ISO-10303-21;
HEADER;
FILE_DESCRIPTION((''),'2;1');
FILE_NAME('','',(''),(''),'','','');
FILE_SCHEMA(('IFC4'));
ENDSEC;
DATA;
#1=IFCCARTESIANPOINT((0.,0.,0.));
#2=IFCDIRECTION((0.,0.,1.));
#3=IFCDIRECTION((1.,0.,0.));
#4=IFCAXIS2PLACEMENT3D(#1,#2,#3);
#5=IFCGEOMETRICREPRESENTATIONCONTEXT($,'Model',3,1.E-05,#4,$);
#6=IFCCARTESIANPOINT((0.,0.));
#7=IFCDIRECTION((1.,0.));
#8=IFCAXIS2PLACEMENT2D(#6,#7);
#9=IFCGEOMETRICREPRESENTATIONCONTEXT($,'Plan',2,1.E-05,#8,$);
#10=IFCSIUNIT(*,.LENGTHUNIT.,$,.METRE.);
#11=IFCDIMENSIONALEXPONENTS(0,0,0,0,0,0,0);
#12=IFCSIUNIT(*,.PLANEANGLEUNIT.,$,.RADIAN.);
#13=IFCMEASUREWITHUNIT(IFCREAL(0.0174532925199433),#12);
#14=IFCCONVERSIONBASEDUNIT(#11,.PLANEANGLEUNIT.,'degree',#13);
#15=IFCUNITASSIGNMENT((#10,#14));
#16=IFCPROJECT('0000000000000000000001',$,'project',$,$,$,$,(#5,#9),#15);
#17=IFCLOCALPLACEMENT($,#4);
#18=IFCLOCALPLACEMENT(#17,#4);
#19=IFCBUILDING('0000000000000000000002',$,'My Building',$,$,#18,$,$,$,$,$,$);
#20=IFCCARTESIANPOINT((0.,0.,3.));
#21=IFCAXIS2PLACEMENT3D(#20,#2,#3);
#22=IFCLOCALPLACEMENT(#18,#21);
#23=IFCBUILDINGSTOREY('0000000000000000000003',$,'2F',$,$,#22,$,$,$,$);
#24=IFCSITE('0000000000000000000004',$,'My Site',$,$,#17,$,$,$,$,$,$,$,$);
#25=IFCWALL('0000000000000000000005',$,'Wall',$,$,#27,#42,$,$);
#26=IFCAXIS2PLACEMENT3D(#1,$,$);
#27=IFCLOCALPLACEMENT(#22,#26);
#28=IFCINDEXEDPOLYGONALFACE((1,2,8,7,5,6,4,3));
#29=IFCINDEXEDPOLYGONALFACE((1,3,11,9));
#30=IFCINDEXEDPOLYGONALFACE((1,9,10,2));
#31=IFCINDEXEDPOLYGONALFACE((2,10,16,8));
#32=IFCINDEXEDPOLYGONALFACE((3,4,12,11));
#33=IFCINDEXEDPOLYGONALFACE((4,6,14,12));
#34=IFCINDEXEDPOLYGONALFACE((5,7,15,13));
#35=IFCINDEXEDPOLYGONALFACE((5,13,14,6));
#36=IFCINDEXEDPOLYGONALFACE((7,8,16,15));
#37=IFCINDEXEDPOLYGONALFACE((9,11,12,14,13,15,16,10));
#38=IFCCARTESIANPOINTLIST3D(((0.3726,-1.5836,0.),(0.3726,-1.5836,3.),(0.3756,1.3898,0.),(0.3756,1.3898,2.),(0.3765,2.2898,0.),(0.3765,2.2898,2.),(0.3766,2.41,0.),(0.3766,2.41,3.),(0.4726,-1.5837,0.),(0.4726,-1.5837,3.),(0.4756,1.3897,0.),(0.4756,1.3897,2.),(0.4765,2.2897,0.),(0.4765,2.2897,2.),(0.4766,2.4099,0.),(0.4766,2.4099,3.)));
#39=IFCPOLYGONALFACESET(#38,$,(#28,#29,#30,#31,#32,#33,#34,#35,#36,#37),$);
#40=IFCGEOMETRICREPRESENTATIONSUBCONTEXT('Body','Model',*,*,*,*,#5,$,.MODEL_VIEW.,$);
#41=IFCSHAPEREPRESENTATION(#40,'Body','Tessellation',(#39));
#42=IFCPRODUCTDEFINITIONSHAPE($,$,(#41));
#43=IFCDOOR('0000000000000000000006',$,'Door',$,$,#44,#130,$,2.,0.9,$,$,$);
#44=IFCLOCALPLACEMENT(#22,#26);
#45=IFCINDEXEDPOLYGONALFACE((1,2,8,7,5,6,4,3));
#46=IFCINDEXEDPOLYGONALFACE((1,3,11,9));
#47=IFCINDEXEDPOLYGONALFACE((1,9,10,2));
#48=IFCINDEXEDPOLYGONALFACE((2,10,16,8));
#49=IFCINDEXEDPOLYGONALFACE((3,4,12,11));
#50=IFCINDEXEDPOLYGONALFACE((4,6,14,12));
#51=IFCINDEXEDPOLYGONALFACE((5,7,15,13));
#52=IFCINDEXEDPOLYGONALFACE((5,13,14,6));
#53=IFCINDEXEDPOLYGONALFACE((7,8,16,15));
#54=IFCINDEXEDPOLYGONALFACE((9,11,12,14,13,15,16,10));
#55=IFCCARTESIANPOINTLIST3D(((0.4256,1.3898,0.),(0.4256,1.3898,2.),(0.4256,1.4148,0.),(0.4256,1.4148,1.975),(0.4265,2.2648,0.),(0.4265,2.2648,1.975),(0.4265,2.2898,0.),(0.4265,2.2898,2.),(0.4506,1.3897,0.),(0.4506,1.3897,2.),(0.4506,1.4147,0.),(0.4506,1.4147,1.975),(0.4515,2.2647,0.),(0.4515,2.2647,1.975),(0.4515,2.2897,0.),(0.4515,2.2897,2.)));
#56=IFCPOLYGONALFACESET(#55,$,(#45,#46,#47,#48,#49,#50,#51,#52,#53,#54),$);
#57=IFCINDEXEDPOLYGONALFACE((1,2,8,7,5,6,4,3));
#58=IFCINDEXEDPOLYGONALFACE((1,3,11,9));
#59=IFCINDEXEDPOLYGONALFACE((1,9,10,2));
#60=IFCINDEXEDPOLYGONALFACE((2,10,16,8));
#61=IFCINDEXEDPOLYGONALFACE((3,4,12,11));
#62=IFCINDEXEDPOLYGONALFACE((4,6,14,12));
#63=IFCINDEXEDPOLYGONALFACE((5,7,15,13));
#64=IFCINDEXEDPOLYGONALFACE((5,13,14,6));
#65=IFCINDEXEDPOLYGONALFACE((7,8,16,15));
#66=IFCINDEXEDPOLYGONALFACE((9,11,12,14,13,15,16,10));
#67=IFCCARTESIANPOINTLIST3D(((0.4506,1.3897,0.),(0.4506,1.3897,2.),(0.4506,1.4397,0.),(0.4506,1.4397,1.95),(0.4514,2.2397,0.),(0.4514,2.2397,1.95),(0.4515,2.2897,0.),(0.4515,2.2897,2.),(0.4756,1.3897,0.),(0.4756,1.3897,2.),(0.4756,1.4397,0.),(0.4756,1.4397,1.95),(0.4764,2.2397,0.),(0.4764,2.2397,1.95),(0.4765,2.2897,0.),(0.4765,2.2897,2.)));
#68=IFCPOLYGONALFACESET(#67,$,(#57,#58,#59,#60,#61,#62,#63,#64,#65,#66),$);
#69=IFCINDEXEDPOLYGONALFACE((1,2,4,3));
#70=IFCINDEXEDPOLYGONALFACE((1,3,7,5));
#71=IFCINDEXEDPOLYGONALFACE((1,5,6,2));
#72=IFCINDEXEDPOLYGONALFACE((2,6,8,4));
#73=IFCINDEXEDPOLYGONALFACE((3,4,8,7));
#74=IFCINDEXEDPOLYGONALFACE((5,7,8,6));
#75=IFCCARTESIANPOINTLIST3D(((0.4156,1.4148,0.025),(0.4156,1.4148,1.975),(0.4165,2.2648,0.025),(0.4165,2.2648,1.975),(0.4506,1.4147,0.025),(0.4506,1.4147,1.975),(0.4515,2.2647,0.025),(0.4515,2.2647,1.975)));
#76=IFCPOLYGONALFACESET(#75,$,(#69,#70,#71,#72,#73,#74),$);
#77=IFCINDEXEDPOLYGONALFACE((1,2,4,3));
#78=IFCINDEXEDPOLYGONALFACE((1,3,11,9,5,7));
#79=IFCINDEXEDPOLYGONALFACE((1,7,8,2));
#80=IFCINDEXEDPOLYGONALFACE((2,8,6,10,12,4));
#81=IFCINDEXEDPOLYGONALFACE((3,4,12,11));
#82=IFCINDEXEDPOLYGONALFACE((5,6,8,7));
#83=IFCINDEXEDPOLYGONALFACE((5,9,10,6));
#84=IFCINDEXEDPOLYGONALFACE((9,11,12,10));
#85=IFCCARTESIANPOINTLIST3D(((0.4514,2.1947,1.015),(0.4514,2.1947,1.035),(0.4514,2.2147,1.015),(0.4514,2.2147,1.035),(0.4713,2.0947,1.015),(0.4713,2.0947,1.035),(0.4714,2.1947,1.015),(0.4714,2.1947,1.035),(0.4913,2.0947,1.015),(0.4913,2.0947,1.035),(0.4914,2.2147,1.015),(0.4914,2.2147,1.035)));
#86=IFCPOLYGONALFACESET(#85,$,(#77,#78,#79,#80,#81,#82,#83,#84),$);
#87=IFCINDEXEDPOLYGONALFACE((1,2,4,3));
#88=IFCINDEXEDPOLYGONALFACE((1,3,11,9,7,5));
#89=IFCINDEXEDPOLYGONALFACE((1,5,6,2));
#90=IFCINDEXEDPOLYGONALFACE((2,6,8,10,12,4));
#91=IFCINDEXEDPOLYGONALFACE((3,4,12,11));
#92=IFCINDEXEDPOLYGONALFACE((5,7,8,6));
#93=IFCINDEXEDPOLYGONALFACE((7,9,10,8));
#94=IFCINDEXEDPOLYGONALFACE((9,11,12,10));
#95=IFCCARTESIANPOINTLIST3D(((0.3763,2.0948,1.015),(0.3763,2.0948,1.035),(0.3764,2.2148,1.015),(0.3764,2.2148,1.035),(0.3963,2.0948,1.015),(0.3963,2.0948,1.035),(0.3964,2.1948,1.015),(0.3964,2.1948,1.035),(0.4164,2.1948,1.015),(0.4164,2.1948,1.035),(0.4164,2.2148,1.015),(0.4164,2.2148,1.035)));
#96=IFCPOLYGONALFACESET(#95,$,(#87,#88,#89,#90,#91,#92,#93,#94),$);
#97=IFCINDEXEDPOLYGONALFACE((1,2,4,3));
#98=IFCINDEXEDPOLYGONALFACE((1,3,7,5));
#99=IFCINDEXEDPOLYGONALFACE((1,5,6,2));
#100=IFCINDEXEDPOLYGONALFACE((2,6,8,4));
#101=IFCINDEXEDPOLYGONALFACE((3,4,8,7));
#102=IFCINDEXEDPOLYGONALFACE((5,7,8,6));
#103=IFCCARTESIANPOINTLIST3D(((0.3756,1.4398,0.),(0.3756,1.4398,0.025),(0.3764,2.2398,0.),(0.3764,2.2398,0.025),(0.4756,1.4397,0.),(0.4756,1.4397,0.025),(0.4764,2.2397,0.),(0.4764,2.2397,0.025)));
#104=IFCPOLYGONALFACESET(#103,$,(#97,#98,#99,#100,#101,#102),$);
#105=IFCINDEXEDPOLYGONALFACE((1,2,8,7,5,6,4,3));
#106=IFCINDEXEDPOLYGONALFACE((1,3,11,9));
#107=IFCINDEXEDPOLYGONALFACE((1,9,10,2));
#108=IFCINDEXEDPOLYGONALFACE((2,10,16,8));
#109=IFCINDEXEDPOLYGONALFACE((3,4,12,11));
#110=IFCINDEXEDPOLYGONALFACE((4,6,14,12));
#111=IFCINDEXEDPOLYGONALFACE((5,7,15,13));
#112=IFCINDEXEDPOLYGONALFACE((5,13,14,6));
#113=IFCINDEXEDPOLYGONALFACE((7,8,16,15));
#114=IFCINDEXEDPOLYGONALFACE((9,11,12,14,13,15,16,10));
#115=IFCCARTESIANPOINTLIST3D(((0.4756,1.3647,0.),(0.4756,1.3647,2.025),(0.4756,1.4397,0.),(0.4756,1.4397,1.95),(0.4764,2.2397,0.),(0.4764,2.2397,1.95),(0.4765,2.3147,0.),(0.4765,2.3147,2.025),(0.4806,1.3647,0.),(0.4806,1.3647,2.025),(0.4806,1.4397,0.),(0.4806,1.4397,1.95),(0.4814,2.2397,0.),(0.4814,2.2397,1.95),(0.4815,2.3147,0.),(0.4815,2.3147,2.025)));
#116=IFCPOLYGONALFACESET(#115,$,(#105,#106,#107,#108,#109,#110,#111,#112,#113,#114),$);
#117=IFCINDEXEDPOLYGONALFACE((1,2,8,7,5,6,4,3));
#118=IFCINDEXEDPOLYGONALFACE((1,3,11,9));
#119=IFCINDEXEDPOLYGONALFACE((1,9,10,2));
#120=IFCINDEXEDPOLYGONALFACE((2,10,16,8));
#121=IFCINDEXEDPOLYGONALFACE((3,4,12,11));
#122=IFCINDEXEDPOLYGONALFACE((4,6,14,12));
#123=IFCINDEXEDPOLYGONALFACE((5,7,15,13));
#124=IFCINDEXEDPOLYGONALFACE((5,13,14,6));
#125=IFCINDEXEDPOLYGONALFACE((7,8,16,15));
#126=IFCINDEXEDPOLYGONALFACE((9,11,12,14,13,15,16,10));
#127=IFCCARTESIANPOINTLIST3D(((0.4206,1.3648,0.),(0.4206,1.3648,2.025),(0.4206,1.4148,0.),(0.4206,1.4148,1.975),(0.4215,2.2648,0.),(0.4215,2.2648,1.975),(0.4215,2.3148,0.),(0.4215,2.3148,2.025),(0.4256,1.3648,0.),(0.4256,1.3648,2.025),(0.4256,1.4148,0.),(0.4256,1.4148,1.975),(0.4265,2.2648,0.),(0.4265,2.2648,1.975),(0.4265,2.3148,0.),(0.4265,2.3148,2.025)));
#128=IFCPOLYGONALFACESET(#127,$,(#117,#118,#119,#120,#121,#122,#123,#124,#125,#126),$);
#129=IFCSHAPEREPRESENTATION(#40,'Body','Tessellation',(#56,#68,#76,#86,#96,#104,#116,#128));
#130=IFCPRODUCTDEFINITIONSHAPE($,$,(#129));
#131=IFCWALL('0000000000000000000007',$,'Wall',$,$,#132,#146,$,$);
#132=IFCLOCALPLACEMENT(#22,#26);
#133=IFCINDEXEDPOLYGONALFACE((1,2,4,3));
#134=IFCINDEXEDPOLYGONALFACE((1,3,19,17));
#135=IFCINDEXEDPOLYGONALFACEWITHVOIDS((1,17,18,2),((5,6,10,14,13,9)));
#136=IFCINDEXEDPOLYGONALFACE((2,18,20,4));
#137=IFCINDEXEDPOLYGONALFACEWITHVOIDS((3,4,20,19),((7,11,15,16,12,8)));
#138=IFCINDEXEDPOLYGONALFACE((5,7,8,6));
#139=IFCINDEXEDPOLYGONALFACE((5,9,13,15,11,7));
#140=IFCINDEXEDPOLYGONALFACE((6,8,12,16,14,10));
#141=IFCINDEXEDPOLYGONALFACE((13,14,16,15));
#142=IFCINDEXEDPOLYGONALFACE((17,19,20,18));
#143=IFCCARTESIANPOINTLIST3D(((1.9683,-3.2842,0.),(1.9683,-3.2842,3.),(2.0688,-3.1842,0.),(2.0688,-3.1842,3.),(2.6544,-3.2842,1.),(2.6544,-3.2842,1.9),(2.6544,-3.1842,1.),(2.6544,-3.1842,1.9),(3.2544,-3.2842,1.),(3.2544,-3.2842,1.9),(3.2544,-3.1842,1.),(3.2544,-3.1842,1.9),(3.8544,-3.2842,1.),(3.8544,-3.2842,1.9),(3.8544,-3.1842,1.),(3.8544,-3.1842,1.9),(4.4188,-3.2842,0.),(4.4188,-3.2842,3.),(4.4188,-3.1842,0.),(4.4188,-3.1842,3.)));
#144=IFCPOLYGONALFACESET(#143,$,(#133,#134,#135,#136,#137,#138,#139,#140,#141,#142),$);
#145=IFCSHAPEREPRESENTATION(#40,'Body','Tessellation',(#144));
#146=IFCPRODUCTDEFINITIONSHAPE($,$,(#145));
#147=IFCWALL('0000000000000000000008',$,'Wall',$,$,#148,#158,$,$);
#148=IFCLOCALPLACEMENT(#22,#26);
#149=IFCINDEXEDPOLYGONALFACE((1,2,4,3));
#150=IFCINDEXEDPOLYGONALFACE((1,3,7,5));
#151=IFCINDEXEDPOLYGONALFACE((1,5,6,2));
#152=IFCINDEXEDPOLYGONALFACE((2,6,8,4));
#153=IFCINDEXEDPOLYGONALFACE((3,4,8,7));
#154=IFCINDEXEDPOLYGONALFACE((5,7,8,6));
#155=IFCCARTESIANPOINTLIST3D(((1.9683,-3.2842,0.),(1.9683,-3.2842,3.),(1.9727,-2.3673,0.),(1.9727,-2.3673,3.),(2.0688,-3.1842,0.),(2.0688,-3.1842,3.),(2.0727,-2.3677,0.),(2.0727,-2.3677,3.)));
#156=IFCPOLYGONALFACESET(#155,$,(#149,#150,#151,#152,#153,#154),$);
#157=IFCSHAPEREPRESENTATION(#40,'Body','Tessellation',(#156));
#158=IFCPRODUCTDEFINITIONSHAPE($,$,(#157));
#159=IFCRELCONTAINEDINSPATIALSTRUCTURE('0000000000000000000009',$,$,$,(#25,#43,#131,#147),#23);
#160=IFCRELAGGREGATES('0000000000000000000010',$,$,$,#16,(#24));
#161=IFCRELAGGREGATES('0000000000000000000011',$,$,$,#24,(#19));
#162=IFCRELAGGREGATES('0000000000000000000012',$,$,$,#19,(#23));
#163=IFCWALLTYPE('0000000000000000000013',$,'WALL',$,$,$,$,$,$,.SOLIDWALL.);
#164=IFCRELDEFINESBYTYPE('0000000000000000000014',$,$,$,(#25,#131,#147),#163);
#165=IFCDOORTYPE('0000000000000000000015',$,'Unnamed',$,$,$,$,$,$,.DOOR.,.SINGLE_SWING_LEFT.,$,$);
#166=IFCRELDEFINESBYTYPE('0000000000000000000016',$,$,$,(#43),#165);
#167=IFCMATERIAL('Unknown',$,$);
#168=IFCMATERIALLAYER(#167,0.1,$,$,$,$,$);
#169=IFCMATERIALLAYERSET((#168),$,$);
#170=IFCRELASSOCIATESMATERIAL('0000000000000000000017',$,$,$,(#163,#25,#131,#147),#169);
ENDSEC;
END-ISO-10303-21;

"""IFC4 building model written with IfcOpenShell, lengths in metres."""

from ifc_helpers import new_model, entity, si_unit, converted_unit, frame, origin_with_axes, origin_2d_with_axis, place, context, subcontext, project, spatial, line, indexed_curve, outline, extrude, shape, source, transform, mapped, material, layer, layer_set, layer_usage, type_object, type_shapes, element, fill, save


model = new_model("IFC4")

# Units and contexts
model_context = context("Model", 3, precision=1e-05, world=origin_with_axes())
plan_context = context("Plan", 2, precision=1e-05, world=origin_2d_with_axis())
body_context_1 = subcontext(model_context, "Body", "Model", "MODEL_VIEW")
body_context_2 = subcontext(plan_context, "Body", "Plan", "PLAN_VIEW")
ifc_project = project(units=[si_unit("LENGTHUNIT", "METRE"), converted_unit("PLANEANGLEUNIT", "degree", entity("IfcReal", 0.0174532925199433), si_unit("PLANEANGLEUNIT", "RADIAN"), dimensions=[0, 0, 0, 0, 0, 0, 0])], contexts=[model_context, plan_context])

# Site, building, storey
site_placement = place(None, origin_with_axes())
site = spatial("IfcSite", under=ifc_project, at=site_placement, Name="My Site")
building_placement = place(site_placement, origin_with_axes())
building = spatial("IfcBuilding", under=site, at=building_placement, Name="My Building")
storey_placement = place(building_placement, frame((0.0, 0.0, 3.0), z_axis=(0.0, 0.0, 1.0), x_axis=(1.0, 0.0, 0.0)))
storey = spatial("IfcBuildingStorey", under=building, at=storey_placement, Name="2F")

# Shared definitions
ifc_material = material(Name="Unknown")

# Shared definitions
ifc_layer_1 = layer(ifc_material, 0.1)
ifc_layer_set_1 = layer_set([ifc_layer_1])
wall_type = type_object("IfcWallType", Name="WALL", PredefinedType="SOLIDWALL", material=ifc_layer_set_1)

# Wall, opening, door
ifc_layer_usage_1 = layer_usage(ifc_layer_set_1, "AXIS2", "POSITIVE", 0.0)
wall_1_placement = place(storey_placement, frame((0.4726, -1.5837, 0.0), z_axis=(0.0, 0.0, 1.0), x_axis=(0.000991, 1.0, 0.0)))
wall_1 = element("IfcWall", 1, at=wall_1_placement, inside=storey, type_object=wall_type, material=ifc_layer_usage_1, Name="Wall", context=body_context_1, shape_type="SweptSolid", body=[
    extrude(outline(indexed_curve([(0.0, 0.0), (0.0, 0.1), (3.9936, 0.1), (3.9936, 0.0)], segments=[line(1, 2, 3, 4, 1)])), origin_with_axes(), (0.0, 0.0, 1.0), 3.0),
])
shared_shape_1 = source(origin_with_axes(), body_context_1, "Body", "SweptSolid", [
    extrude(outline(indexed_curve([(0.0, 0.0), (0.9, 0.0), (0.9, 2.0), (0.0, 2.0)], segments=[line(1, 2, 3, 4, 1)])), frame((0.0, -0.6, 0.0), z_axis=(0.0, -1.0, 0.0), x_axis=(1.0, 0.0, 0.0)), (0.0, 0.0, -1.0), 1.2),
])
opening_1_placement = place(wall_1_placement, frame((2.9734, 0.0, 0.0), z_axis=(0.0, 0.0, 1.0), x_axis=(1.0, 0.0, 0.0)))
opening_1 = element("IfcOpeningElement", 2, at=opening_1_placement, cuts=wall_1, PredefinedType="OPENING", context=body_context_1, shape_type="MappedRepresentation", body=[
    mapped(shared_shape_1, transform((0.0, 0.0, 0.0), x_axis=(1.0, 0.0, 0.0), y_axis=(0.0, 1.0, 0.0), z_axis=(0.0, 0.0, 1.0), scale=1.0)),
])
door_type = type_object("IfcDoorType", Name="Unnamed", OperationType="SINGLE_SWING_LEFT", PredefinedType="DOOR")
shared_shape_2 = source(origin_with_axes(), body_context_1, "Body", "SweptSolid", [
    extrude(outline(indexed_curve([(0.0, 0.0), (0.0, 2.0), (0.9, 2.0), (0.9, 0.0), (0.875, 0.0), (0.875, 1.975), (0.025, 1.975), (0.025, 0.0)], segments=[line(1, 2, 3, 4, 5, 6, 7, 8, 1)])), frame((0.0, 0.025, 0.0), z_axis=(0.0, -1.0, 0.0), x_axis=(1.0, 0.0, 0.0)), (0.0, 0.0, -1.0), 0.025),
    extrude(outline(indexed_curve([(0.0, 0.0), (0.0, 2.0), (0.9, 2.0), (0.9, 0.0), (0.85, 0.0), (0.85, 1.95), (0.05, 1.95), (0.05, 0.0)], segments=[line(1, 2, 3, 4, 5, 6, 7, 8, 1)])), frame((0.0, 0.0, 0.0), z_axis=(0.0, -1.0, 0.0), x_axis=(1.0, 0.0, 0.0)), (0.0, 0.0, -1.0), 0.025),
    extrude(outline(indexed_curve([(0.0, 0.0), (0.85, 0.0), (0.85, 0.035), (0.0, 0.035)], segments=[line(1, 2, 3, 4, 1)])), frame((0.025, 0.025, 0.025), z_axis=(0.0, 0.0, 1.0), x_axis=(1.0, 0.0, 0.0)), (0.0, 0.0, 1.0), 1.95),
    extrude(outline(indexed_curve([(0.0, 0.0), (0.0, -0.04), (-0.12, -0.04), (-0.12, -0.02), (-0.02, -0.02), (-0.02, 0.0)], segments=[line(1, 2, 3, 4, 5, 6, 1)])), frame((0.825, 0.025, 1.015), z_axis=(0.0, 0.0, 1.0), x_axis=(1.0, 0.0, 0.0)), (0.0, 0.0, 1.0), 0.02),
    extrude(outline(indexed_curve([(0.0, 0.0), (0.0, 0.04), (-0.12, 0.04), (-0.12, 0.02), (-0.02, 0.02), (-0.02, 0.0)], segments=[line(1, 2, 3, 4, 5, 6, 1)])), frame((0.825, 0.06, 1.015), z_axis=(0.0, 0.0, 1.0), x_axis=(1.0, 0.0, 0.0)), (0.0, 0.0, 1.0), 0.02),
    extrude(outline(indexed_curve([(0.0, 0.0), (0.8, 0.0), (0.8, 0.1), (0.0, 0.1)], segments=[line(1, 2, 3, 4, 1)])), frame((0.05, 0.0, 0.0), z_axis=(0.0, 0.0, 1.0), x_axis=(1.0, 0.0, 0.0)), (0.0, 0.0, 1.0), 0.025),
    extrude(outline(indexed_curve([(0.0, 0.0), (0.0, 2.025), (0.95, 2.025), (0.95, 0.0), (0.875, 0.0), (0.875, 1.95), (0.075, 1.95), (0.075, 0.0)], segments=[line(1, 2, 3, 4, 5, 6, 7, 8, 1)])), frame((-0.025, -0.005, 0.0), z_axis=(0.0, -1.0, 0.0), x_axis=(1.0, 0.0, 0.0)), (0.0, 0.0, -1.0), 0.005),
    extrude(outline(indexed_curve([(0.0, 0.0), (0.0, 2.025), (0.95, 2.025), (0.95, 0.0), (0.9, 0.0), (0.9, 1.975), (0.05, 1.975), (0.05, 0.0)], segments=[line(1, 2, 3, 4, 5, 6, 7, 8, 1)])), frame((-0.025, 0.05, 0.0), z_axis=(0.0, -1.0, 0.0), x_axis=(1.0, 0.0, 0.0)), (0.0, 0.0, -1.0), 0.005),
])
shared_shape_3 = source(origin_with_axes(), body_context_2, "Body", "Curve2D", [
    entity("IfcIndexedPolyCurve", entity("IfcCartesianPointList2D", [[0.0, 0.0], [0.0, 0.05], [0.025, 0.05], [0.025, 0.025], [0.05, 0.025], [0.05, 0.0]]), [entity("IfcLineIndex", [1, 2, 3, 4, 5, 6, 1])]),
    entity("IfcIndexedPolyCurve", entity("IfcCartesianPointList2D", [[0.9, 0.0], [0.9, 0.05], [0.875, 0.05], [0.875, 0.025], [0.85, 0.025], [0.85, 0.0]]), [entity("IfcLineIndex", [1, 2, 3, 4, 5, 6, 1])]),
    entity("IfcTrimmedCurve", entity("IfcEllipse", entity("IfcAxis2Placement2D", entity("IfcCartesianPoint", [0.06, 0.05]), entity("IfcDirection", [1.0, 0.0])), 0.815, 0.85), [entity("IfcCartesianPoint", [0.875, 0.05])], [entity("IfcCartesianPoint", [0.06, 0.9])], True, "CARTESIAN"),
    entity("IfcIndexedPolyCurve", entity("IfcCartesianPointList2D", [[0.025, 0.05], [0.06, 0.05], [0.06, 0.9], [0.025, 0.9]]), [entity("IfcLineIndex", [1, 2, 3, 4, 1])]),
])
type_shapes(door_type, [shared_shape_2, shared_shape_3])
door_1_placement = place(opening_1_placement, frame((0.0, 0.0, 0.0), z_axis=(0.0, 0.0, 1.0), x_axis=(1.0, 0.0, 0.0)))
door_1 = element("IfcDoor", 3, at=door_1_placement, inside=storey, type_object=door_type, Name="Door", OverallHeight=2.0, OverallWidth=0.9, shapes=[
    shape(body_context_1, "Body", "MappedRepresentation", [mapped(shared_shape_2, transform((0.0, 0.0, 0.0), x_axis=(1.0, 0.0, 0.0), y_axis=(0.0, 1.0, 0.0), z_axis=(0.0, 0.0, 1.0), scale=1.0))]),
    shape(body_context_2, "Body", "MappedRepresentation", [mapped(shared_shape_3, transform((0.0, 0.0, 0.0), x_axis=(1.0, 0.0, 0.0), y_axis=(0.0, 1.0, 0.0), z_axis=(0.0, 0.0, 1.0), scale=1.0))]),
])
fill(opening_1, door_1)

# Wall, openings
ifc_layer_usage_2 = layer_usage(ifc_layer_set_1, "AXIS2", "POSITIVE", 0.0)
wall_2_placement = place(storey_placement, frame((4.4188, -3.1842, 0.0), z_axis=(0.0, 0.0, 1.0), x_axis=(-1.0, 0.0, 0.0)))
wall_2 = element("IfcWall", 4, at=wall_2_placement, inside=storey, type_object=wall_type, material=ifc_layer_usage_2, Name="Wall", context=body_context_1, shape_type="SweptSolid", body=[
    extrude(outline(indexed_curve([(0.0, 0.0), (0.0, 0.1), (2.4505, 0.1), (2.35, 0.0)], segments=[line(1, 2, 3, 4, 1)])), origin_with_axes(), (0.0, 0.0, 1.0), 3.0),
])
shared_shape_4 = source(origin_with_axes(), body_context_1, "Body", "SweptSolid", [
    extrude(outline(indexed_curve([(0.0, 0.0), (0.6, 0.0), (0.6, 0.9), (0.0, 0.9)], segments=[line(1, 2, 3, 4, 1)])), frame((0.0, -0.6, 0.0), z_axis=(0.0, -1.0, 0.0), x_axis=(1.0, 0.0, 0.0)), (0.0, 0.0, -1.0), 1.2),
])
opening_2_placement = place(wall_2_placement, frame((0.5644, 0.0, 1.0), z_axis=(0.0, 0.0, 1.0), x_axis=(1.0, 0.0, 0.0)))
element("IfcOpeningElement", 5, at=opening_2_placement, cuts=wall_2, PredefinedType="OPENING", context=body_context_1, shape_type="MappedRepresentation", body=[
    mapped(shared_shape_4, transform((0.0, 0.0, 0.0), x_axis=(1.0, 0.0, 0.0), y_axis=(0.0, 1.0, 0.0), z_axis=(0.0, 0.0, 1.0), scale=1.0)),
])
opening_3_placement = place(wall_2_placement, frame((1.1644, 0.0, 1.0), z_axis=(0.0, 0.0, 1.0), x_axis=(1.0, 0.0, 0.0)))
element("IfcOpeningElement", 6, at=opening_3_placement, cuts=wall_2, PredefinedType="OPENING", context=body_context_1, shape_type="MappedRepresentation", body=[
    mapped(shared_shape_4, transform((0.0, 0.0, 0.0), x_axis=(1.0, 0.0, 0.0), y_axis=(0.0, 1.0, 0.0), z_axis=(0.0, 0.0, 1.0), scale=1.0)),
])

# Wall
ifc_layer_usage_3 = layer_usage(ifc_layer_set_1, "AXIS2", "POSITIVE", 0.0)
wall_3_placement = place(storey_placement, frame((2.0688, -3.1842, 0.0), z_axis=(0.0, 0.0, 1.0), x_axis=(0.00477, 0.999989, 0.0)))
element("IfcWall", 7, at=wall_3_placement, inside=storey, type_object=wall_type, material=ifc_layer_usage_3, Name="Wall", context=body_context_1, shape_type="SweptSolid", body=[
    extrude(outline(indexed_curve([(0.0, 0.0), (-0.1005, 0.1), (0.8165, 0.1), (0.8165, 0.0)], segments=[line(1, 2, 3, 4, 1)])), origin_with_axes(), (0.0, 0.0, 1.0), 3.0),
])

save(model, "model.ifc")
